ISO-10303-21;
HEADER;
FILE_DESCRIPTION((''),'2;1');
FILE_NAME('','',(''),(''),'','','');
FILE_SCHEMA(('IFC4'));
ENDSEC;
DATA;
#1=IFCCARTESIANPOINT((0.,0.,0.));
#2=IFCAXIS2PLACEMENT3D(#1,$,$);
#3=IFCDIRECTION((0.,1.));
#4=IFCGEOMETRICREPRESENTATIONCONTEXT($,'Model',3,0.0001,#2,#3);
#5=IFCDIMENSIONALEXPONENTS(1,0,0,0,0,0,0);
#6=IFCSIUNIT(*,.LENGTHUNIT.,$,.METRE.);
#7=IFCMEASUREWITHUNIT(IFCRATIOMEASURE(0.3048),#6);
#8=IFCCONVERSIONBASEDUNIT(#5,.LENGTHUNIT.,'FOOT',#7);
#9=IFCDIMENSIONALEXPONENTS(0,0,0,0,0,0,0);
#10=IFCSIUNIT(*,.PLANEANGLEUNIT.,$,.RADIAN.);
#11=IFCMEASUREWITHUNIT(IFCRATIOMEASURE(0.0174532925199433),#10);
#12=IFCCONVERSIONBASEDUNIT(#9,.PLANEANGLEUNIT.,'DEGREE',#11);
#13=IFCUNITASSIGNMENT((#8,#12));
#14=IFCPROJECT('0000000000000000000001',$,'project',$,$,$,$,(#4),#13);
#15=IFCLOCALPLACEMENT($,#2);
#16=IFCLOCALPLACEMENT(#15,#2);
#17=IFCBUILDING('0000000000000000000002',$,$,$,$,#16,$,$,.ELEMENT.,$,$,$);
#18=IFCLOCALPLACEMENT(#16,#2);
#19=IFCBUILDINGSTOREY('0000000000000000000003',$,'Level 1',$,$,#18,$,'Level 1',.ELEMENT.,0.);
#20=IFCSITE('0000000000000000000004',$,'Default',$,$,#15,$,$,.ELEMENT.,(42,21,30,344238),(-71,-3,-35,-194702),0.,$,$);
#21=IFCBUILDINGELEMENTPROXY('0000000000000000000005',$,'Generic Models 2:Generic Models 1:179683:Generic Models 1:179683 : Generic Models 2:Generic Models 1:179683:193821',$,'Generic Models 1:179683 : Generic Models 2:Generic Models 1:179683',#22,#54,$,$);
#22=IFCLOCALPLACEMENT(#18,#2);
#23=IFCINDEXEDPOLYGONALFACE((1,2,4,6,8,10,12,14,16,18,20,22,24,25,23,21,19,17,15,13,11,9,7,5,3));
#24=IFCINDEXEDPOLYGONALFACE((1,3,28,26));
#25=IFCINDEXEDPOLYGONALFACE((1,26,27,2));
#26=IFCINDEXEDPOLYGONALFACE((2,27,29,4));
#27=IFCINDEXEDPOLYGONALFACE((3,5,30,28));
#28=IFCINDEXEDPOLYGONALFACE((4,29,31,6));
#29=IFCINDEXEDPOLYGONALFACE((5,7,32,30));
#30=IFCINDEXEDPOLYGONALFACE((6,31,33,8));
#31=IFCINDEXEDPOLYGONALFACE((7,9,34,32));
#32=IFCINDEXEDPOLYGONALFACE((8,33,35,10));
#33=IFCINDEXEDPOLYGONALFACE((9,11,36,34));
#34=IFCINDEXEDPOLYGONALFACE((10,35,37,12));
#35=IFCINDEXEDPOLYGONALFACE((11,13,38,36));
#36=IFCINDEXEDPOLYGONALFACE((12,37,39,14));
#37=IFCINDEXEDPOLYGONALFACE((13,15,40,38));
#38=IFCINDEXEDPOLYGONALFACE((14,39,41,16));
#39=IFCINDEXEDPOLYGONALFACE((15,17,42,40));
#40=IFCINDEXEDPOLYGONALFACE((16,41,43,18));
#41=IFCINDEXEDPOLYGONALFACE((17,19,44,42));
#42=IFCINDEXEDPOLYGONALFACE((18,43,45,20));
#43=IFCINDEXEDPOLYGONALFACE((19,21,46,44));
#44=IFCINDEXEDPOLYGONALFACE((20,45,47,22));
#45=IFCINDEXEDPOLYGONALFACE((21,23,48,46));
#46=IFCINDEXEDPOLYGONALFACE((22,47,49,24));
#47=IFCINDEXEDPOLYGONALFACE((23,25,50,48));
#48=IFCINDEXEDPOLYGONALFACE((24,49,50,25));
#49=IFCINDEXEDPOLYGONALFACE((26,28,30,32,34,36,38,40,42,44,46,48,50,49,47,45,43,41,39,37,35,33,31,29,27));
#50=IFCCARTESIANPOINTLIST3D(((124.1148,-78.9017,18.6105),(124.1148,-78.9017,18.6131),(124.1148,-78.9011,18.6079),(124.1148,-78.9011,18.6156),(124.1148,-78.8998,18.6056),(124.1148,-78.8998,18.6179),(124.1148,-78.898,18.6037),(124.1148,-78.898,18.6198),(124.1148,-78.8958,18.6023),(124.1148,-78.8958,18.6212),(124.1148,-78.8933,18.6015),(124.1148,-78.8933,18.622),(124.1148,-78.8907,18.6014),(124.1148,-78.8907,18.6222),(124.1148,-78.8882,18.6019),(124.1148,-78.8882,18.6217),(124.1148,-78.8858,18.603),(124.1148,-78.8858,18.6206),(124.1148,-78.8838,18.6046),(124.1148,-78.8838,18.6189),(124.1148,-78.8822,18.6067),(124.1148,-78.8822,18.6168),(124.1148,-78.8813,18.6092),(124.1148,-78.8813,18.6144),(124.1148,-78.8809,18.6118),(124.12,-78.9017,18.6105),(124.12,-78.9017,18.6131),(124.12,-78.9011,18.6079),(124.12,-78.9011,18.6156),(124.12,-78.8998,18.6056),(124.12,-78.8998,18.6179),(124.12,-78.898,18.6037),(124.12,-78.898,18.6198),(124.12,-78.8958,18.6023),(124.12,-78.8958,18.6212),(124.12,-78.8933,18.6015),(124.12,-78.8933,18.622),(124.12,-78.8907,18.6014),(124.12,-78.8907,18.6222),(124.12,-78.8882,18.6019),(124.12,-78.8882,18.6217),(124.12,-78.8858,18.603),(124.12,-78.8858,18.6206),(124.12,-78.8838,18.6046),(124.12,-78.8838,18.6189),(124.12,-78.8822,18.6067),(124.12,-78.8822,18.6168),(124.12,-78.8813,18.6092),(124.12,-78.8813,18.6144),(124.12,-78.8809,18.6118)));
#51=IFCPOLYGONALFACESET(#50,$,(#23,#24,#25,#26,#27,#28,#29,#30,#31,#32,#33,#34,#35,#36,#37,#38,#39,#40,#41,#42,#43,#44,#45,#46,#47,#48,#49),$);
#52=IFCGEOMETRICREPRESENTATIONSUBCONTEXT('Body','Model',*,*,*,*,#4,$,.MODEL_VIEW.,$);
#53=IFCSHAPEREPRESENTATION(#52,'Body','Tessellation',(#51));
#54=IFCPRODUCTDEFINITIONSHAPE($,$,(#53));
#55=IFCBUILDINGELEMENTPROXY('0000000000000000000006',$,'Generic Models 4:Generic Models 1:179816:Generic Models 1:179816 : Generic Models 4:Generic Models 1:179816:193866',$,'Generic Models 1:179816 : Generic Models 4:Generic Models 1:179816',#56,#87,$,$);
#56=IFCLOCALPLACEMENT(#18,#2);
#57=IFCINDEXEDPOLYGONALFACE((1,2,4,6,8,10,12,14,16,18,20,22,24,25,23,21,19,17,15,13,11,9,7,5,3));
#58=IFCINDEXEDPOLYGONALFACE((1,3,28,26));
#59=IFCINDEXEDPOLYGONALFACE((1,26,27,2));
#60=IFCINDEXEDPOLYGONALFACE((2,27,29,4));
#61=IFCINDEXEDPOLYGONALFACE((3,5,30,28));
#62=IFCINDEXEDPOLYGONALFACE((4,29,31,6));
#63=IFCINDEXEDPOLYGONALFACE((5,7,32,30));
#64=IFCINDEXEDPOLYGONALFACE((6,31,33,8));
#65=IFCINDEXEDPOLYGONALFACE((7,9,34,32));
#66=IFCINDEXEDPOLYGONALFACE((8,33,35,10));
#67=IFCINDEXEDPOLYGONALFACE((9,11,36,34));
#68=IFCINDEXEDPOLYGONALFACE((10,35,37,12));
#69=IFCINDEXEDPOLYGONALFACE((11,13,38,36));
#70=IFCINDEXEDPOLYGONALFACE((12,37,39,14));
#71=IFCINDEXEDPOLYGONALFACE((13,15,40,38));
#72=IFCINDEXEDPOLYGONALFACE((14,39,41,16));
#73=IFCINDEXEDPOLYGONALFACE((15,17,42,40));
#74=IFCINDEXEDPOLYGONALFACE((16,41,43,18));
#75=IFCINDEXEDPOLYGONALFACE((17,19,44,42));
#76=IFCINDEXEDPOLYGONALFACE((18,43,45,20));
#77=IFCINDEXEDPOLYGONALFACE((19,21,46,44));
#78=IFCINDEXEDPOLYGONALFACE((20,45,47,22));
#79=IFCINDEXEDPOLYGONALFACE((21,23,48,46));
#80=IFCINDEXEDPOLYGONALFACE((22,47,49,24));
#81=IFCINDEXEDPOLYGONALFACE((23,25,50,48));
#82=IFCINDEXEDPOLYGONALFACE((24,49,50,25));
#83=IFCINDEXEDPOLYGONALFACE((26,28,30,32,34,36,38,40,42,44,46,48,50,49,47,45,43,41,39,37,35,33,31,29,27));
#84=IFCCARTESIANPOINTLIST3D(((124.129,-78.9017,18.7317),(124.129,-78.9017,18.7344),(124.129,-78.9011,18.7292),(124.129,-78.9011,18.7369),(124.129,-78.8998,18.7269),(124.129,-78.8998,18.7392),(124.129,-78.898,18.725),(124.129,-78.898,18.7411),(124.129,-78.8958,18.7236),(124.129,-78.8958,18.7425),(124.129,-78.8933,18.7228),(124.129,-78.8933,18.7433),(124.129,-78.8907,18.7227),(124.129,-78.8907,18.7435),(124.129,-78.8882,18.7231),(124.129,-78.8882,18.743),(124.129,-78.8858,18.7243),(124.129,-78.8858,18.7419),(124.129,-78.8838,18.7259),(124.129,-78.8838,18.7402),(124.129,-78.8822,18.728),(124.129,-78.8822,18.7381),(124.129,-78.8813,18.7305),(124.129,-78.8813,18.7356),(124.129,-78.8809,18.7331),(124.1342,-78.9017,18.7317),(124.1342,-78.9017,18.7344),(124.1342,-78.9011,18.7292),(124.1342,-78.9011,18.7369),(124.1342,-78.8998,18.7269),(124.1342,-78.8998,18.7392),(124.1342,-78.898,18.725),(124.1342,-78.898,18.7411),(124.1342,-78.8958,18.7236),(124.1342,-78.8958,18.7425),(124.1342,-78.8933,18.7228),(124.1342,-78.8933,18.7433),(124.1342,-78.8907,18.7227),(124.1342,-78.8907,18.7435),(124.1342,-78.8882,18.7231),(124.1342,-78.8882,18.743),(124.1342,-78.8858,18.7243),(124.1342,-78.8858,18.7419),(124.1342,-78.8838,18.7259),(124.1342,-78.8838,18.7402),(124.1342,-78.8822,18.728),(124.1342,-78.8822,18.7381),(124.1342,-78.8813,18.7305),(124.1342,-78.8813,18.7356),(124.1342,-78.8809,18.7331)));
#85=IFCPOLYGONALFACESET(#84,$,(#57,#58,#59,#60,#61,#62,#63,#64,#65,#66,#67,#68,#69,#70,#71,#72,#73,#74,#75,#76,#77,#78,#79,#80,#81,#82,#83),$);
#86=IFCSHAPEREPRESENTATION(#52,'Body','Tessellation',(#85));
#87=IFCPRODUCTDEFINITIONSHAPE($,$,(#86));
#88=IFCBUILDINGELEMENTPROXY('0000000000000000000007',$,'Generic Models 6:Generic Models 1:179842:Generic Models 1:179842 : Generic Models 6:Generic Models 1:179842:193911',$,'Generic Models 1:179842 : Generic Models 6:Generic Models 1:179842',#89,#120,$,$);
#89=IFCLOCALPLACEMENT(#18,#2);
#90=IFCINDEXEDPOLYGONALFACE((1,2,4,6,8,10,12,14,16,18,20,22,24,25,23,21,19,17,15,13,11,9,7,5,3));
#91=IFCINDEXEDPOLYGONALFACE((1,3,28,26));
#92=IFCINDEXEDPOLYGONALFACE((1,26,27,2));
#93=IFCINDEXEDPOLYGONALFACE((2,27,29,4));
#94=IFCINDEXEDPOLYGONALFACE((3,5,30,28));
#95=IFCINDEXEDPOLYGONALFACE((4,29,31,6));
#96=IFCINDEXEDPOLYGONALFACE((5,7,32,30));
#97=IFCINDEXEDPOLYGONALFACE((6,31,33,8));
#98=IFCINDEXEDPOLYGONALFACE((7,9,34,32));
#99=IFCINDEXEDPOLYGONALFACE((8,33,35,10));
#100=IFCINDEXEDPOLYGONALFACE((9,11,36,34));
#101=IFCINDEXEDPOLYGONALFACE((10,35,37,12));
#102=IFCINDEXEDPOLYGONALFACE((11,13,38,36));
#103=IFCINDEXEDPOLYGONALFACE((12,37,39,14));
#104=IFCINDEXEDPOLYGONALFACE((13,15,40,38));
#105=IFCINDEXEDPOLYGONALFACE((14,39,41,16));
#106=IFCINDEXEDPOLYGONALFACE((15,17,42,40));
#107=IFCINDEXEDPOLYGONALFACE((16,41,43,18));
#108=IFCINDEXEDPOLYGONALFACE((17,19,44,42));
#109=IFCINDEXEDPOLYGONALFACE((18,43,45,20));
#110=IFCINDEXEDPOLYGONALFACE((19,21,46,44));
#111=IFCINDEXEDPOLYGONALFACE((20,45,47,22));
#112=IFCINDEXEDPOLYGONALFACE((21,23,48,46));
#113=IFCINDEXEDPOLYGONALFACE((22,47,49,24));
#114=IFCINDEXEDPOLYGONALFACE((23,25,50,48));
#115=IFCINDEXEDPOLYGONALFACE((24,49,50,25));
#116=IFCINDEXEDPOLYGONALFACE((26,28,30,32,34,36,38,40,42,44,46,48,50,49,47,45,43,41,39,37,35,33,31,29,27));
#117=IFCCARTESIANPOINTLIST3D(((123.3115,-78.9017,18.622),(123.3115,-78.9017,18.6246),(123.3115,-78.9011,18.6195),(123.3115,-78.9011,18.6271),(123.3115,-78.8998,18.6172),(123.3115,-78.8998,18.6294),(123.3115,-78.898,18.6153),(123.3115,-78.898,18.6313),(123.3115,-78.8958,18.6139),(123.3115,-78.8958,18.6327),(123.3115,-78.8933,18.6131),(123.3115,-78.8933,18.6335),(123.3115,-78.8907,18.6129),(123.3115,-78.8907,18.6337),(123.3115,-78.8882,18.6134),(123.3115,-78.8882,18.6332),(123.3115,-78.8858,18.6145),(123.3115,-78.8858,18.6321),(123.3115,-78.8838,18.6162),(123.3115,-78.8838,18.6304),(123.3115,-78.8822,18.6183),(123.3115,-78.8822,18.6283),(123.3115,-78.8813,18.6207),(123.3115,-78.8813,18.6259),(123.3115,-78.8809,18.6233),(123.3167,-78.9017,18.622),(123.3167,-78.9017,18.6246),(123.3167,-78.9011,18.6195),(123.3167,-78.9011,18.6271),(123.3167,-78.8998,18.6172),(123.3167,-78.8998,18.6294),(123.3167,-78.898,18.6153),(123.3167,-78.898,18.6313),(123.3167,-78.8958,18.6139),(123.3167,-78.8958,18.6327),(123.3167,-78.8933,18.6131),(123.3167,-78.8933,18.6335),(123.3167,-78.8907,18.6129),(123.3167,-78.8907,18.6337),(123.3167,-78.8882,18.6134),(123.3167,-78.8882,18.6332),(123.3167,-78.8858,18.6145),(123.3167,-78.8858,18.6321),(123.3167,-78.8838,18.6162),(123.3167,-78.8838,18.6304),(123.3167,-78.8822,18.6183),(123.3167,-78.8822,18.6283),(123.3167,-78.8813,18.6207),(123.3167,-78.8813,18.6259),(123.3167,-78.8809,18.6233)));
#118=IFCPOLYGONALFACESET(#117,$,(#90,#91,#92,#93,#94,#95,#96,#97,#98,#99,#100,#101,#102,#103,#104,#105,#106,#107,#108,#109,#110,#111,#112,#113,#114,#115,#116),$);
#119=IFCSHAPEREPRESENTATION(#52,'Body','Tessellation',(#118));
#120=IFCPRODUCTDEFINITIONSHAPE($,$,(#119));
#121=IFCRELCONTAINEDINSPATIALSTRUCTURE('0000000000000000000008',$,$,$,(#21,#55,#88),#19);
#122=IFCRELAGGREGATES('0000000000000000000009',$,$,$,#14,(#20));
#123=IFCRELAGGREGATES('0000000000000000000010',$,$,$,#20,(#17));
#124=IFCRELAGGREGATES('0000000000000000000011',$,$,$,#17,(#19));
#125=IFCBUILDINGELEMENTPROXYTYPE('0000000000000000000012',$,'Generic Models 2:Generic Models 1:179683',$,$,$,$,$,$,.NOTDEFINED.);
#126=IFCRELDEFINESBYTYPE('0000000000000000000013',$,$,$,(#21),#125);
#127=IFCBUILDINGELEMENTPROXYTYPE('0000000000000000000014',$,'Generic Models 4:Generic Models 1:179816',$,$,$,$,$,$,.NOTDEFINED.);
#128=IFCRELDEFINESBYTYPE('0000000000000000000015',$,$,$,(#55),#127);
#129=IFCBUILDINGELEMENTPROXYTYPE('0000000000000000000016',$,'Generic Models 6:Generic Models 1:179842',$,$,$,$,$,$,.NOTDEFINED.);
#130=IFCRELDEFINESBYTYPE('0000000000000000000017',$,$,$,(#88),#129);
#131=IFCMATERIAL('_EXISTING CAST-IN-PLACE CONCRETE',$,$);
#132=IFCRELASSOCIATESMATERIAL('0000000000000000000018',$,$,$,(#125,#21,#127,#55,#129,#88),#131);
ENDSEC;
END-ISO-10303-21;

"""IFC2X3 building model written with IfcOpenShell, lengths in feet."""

from ifc_helpers import new_model, entity, si_unit, converted_unit, direction, frame, origin, place, context, subcontext, project, spatial, polyline, outline, extrude, source, transform, mapped, material, type_object, type_shapes, element, save


model = new_model("IFC2X3")

# Units and contexts
model_context = context("Model", 3, precision=0.0001, world=origin(), true_north=direction((0.0, 1.0)))
body_context = subcontext(model_context, "Body", "Model", "MODEL_VIEW")
ifc_project = project(units=[converted_unit("LENGTHUNIT", "FOOT", entity("IfcRatioMeasure", 0.3048), si_unit("LENGTHUNIT", "METRE"), dimensions=[1, 0, 0, 0, 0, 0, 0]), converted_unit("PLANEANGLEUNIT", "DEGREE", entity("IfcRatioMeasure", 0.0174532925199433), si_unit("PLANEANGLEUNIT", "RADIAN"), dimensions=[0, 0, 0, 0, 0, 0, 0])], contexts=[model_context])

# Site, building, storey
site_placement = place(None, origin())
site = spatial("IfcSite", under=ifc_project, at=site_placement, Name="Default", CompositionType="ELEMENT", RefLatitude=(42, 21, 30, 344238), RefLongitude=(-71, -3, -35, -194702), RefElevation=0.0)
building_placement = place(site_placement, origin())
building = spatial("IfcBuilding", under=site, at=building_placement, CompositionType="ELEMENT")
storey_placement = place(building_placement, origin())
storey = spatial("IfcBuildingStorey", under=building, at=storey_placement, Name="Level 1", LongName="Level 1", CompositionType="ELEMENT", Elevation=0.0)

# Building element proxies
ifc_material_1 = material(Name="_EXISTING CAST-IN-PLACE CONCRETE")
building_element_proxy_type_1 = type_object("IfcBuildingElementProxyType", Name="Generic Models 2:Generic Models 1:179683", PredefinedType="NOTDEFINED", material=ifc_material_1)
shared_shape_1 = source(origin(), body_context, "Body", "SweptSolid", [
    extrude(outline(polyline([(-0.0013, -0.0103), (0.0013, -0.0103), (0.0038, -0.0097), (0.0061, -0.0084), (0.008, -0.0066), (0.0094, -0.0044), (0.0102, -0.0019), (0.0104, 0.0007), (0.0099, 0.0032), (0.0088, 0.0056), (0.0071, 0.0076), (0.005, 0.0091), (0.0026, 0.0101), (0.0, 0.0104), (-0.0026, 0.0101), (-0.005, 0.0091), (-0.0071, 0.0076), (-0.0088, 0.0056), (-0.0099, 0.0032), (-0.0104, 0.0006), (-0.0102, -0.002), (-0.0094, -0.0044), (-0.008, -0.0067), (-0.0061, -0.0084), (-0.0038, -0.0097), (-0.0013, -0.0103)])), frame((124.1148, -78.8914, 18.6118), z_axis=(1.0, 0.0, 0.0), x_axis=(0.0, -0.366839, 0.930284)), (0.0, 0.0, 1.0), 0.0052),
])
type_shapes(building_element_proxy_type_1, [shared_shape_1])
proxy_1_placement = place(storey_placement, origin())
element("IfcBuildingElementProxy", 1, at=proxy_1_placement, inside=storey, type_object=building_element_proxy_type_1, material=ifc_material_1, Name="Generic Models 2:Generic Models 1:179683:Generic Models 1:179683 : Generic Models 2:Generic Models 1:179683:193821", ObjectType="Generic Models 1:179683 : Generic Models 2:Generic Models 1:179683", context=body_context, shape_type="MappedRepresentation", body=[
    mapped(shared_shape_1, transform((0.0, 0.0, 0.0), scale=1.0)),
])
building_element_proxy_type_2 = type_object("IfcBuildingElementProxyType", Name="Generic Models 4:Generic Models 1:179816", PredefinedType="NOTDEFINED", material=ifc_material_1)
shared_shape_2 = source(origin(), body_context, "Body", "SweptSolid", [
    extrude(outline(polyline([(-0.0013, -0.0103), (0.0013, -0.0103), (0.0038, -0.0097), (0.0061, -0.0084), (0.008, -0.0066), (0.0094, -0.0044), (0.0102, -0.0019), (0.0104, 0.0007), (0.0099, 0.0032), (0.0088, 0.0056), (0.0071, 0.0076), (0.005, 0.0091), (0.0026, 0.0101), (0.0, 0.0104), (-0.0026, 0.0101), (-0.005, 0.0091), (-0.0071, 0.0076), (-0.0088, 0.0056), (-0.0099, 0.0032), (-0.0104, 0.0006), (-0.0102, -0.002), (-0.0094, -0.0044), (-0.008, -0.0067), (-0.0061, -0.0084), (-0.0038, -0.0097), (-0.0013, -0.0103)])), frame((124.129, -78.8914, 18.7331), z_axis=(1.0, 0.0, 0.0), x_axis=(0.0, -0.366839, 0.930284)), (0.0, 0.0, 1.0), 0.0052),
])
type_shapes(building_element_proxy_type_2, [shared_shape_2])
proxy_2_placement = place(storey_placement, origin())
element("IfcBuildingElementProxy", 2, at=proxy_2_placement, inside=storey, type_object=building_element_proxy_type_2, material=ifc_material_1, Name="Generic Models 4:Generic Models 1:179816:Generic Models 1:179816 : Generic Models 4:Generic Models 1:179816:193866", ObjectType="Generic Models 1:179816 : Generic Models 4:Generic Models 1:179816", context=body_context, shape_type="MappedRepresentation", body=[
    mapped(shared_shape_2, transform((0.0, 0.0, 0.0), scale=1.0)),
])
building_element_proxy_type_3 = type_object("IfcBuildingElementProxyType", Name="Generic Models 6:Generic Models 1:179842", PredefinedType="NOTDEFINED", material=ifc_material_1)
shared_shape_3 = source(origin(), body_context, "Body", "SweptSolid", [
    extrude(outline(polyline([(-0.0013, -0.0103), (0.0013, -0.0103), (0.0038, -0.0097), (0.0061, -0.0084), (0.008, -0.0066), (0.0094, -0.0044), (0.0102, -0.0019), (0.0104, 0.0007), (0.0099, 0.0032), (0.0088, 0.0056), (0.0071, 0.0076), (0.005, 0.0091), (0.0026, 0.0101), (0.0, 0.0104), (-0.0026, 0.0101), (-0.005, 0.0091), (-0.0071, 0.0076), (-0.0088, 0.0056), (-0.0099, 0.0032), (-0.0104, 0.0006), (-0.0102, -0.002), (-0.0094, -0.0044), (-0.008, -0.0067), (-0.0061, -0.0084), (-0.0038, -0.0097), (-0.0013, -0.0103)])), frame((123.3115, -78.8914, 18.6233), z_axis=(1.0, 0.0, 0.0), x_axis=(0.0, -0.366839, 0.930284)), (0.0, 0.0, 1.0), 0.0052),
])
type_shapes(building_element_proxy_type_3, [shared_shape_3])
proxy_3_placement = place(storey_placement, origin())
element("IfcBuildingElementProxy", 3, at=proxy_3_placement, inside=storey, type_object=building_element_proxy_type_3, material=ifc_material_1, Name="Generic Models 6:Generic Models 1:179842:Generic Models 1:179842 : Generic Models 6:Generic Models 1:179842:193911", ObjectType="Generic Models 1:179842 : Generic Models 6:Generic Models 1:179842", context=body_context, shape_type="MappedRepresentation", body=[
    mapped(shared_shape_3, transform((0.0, 0.0, 0.0), scale=1.0)),
])

save(model, "model.ifc")
